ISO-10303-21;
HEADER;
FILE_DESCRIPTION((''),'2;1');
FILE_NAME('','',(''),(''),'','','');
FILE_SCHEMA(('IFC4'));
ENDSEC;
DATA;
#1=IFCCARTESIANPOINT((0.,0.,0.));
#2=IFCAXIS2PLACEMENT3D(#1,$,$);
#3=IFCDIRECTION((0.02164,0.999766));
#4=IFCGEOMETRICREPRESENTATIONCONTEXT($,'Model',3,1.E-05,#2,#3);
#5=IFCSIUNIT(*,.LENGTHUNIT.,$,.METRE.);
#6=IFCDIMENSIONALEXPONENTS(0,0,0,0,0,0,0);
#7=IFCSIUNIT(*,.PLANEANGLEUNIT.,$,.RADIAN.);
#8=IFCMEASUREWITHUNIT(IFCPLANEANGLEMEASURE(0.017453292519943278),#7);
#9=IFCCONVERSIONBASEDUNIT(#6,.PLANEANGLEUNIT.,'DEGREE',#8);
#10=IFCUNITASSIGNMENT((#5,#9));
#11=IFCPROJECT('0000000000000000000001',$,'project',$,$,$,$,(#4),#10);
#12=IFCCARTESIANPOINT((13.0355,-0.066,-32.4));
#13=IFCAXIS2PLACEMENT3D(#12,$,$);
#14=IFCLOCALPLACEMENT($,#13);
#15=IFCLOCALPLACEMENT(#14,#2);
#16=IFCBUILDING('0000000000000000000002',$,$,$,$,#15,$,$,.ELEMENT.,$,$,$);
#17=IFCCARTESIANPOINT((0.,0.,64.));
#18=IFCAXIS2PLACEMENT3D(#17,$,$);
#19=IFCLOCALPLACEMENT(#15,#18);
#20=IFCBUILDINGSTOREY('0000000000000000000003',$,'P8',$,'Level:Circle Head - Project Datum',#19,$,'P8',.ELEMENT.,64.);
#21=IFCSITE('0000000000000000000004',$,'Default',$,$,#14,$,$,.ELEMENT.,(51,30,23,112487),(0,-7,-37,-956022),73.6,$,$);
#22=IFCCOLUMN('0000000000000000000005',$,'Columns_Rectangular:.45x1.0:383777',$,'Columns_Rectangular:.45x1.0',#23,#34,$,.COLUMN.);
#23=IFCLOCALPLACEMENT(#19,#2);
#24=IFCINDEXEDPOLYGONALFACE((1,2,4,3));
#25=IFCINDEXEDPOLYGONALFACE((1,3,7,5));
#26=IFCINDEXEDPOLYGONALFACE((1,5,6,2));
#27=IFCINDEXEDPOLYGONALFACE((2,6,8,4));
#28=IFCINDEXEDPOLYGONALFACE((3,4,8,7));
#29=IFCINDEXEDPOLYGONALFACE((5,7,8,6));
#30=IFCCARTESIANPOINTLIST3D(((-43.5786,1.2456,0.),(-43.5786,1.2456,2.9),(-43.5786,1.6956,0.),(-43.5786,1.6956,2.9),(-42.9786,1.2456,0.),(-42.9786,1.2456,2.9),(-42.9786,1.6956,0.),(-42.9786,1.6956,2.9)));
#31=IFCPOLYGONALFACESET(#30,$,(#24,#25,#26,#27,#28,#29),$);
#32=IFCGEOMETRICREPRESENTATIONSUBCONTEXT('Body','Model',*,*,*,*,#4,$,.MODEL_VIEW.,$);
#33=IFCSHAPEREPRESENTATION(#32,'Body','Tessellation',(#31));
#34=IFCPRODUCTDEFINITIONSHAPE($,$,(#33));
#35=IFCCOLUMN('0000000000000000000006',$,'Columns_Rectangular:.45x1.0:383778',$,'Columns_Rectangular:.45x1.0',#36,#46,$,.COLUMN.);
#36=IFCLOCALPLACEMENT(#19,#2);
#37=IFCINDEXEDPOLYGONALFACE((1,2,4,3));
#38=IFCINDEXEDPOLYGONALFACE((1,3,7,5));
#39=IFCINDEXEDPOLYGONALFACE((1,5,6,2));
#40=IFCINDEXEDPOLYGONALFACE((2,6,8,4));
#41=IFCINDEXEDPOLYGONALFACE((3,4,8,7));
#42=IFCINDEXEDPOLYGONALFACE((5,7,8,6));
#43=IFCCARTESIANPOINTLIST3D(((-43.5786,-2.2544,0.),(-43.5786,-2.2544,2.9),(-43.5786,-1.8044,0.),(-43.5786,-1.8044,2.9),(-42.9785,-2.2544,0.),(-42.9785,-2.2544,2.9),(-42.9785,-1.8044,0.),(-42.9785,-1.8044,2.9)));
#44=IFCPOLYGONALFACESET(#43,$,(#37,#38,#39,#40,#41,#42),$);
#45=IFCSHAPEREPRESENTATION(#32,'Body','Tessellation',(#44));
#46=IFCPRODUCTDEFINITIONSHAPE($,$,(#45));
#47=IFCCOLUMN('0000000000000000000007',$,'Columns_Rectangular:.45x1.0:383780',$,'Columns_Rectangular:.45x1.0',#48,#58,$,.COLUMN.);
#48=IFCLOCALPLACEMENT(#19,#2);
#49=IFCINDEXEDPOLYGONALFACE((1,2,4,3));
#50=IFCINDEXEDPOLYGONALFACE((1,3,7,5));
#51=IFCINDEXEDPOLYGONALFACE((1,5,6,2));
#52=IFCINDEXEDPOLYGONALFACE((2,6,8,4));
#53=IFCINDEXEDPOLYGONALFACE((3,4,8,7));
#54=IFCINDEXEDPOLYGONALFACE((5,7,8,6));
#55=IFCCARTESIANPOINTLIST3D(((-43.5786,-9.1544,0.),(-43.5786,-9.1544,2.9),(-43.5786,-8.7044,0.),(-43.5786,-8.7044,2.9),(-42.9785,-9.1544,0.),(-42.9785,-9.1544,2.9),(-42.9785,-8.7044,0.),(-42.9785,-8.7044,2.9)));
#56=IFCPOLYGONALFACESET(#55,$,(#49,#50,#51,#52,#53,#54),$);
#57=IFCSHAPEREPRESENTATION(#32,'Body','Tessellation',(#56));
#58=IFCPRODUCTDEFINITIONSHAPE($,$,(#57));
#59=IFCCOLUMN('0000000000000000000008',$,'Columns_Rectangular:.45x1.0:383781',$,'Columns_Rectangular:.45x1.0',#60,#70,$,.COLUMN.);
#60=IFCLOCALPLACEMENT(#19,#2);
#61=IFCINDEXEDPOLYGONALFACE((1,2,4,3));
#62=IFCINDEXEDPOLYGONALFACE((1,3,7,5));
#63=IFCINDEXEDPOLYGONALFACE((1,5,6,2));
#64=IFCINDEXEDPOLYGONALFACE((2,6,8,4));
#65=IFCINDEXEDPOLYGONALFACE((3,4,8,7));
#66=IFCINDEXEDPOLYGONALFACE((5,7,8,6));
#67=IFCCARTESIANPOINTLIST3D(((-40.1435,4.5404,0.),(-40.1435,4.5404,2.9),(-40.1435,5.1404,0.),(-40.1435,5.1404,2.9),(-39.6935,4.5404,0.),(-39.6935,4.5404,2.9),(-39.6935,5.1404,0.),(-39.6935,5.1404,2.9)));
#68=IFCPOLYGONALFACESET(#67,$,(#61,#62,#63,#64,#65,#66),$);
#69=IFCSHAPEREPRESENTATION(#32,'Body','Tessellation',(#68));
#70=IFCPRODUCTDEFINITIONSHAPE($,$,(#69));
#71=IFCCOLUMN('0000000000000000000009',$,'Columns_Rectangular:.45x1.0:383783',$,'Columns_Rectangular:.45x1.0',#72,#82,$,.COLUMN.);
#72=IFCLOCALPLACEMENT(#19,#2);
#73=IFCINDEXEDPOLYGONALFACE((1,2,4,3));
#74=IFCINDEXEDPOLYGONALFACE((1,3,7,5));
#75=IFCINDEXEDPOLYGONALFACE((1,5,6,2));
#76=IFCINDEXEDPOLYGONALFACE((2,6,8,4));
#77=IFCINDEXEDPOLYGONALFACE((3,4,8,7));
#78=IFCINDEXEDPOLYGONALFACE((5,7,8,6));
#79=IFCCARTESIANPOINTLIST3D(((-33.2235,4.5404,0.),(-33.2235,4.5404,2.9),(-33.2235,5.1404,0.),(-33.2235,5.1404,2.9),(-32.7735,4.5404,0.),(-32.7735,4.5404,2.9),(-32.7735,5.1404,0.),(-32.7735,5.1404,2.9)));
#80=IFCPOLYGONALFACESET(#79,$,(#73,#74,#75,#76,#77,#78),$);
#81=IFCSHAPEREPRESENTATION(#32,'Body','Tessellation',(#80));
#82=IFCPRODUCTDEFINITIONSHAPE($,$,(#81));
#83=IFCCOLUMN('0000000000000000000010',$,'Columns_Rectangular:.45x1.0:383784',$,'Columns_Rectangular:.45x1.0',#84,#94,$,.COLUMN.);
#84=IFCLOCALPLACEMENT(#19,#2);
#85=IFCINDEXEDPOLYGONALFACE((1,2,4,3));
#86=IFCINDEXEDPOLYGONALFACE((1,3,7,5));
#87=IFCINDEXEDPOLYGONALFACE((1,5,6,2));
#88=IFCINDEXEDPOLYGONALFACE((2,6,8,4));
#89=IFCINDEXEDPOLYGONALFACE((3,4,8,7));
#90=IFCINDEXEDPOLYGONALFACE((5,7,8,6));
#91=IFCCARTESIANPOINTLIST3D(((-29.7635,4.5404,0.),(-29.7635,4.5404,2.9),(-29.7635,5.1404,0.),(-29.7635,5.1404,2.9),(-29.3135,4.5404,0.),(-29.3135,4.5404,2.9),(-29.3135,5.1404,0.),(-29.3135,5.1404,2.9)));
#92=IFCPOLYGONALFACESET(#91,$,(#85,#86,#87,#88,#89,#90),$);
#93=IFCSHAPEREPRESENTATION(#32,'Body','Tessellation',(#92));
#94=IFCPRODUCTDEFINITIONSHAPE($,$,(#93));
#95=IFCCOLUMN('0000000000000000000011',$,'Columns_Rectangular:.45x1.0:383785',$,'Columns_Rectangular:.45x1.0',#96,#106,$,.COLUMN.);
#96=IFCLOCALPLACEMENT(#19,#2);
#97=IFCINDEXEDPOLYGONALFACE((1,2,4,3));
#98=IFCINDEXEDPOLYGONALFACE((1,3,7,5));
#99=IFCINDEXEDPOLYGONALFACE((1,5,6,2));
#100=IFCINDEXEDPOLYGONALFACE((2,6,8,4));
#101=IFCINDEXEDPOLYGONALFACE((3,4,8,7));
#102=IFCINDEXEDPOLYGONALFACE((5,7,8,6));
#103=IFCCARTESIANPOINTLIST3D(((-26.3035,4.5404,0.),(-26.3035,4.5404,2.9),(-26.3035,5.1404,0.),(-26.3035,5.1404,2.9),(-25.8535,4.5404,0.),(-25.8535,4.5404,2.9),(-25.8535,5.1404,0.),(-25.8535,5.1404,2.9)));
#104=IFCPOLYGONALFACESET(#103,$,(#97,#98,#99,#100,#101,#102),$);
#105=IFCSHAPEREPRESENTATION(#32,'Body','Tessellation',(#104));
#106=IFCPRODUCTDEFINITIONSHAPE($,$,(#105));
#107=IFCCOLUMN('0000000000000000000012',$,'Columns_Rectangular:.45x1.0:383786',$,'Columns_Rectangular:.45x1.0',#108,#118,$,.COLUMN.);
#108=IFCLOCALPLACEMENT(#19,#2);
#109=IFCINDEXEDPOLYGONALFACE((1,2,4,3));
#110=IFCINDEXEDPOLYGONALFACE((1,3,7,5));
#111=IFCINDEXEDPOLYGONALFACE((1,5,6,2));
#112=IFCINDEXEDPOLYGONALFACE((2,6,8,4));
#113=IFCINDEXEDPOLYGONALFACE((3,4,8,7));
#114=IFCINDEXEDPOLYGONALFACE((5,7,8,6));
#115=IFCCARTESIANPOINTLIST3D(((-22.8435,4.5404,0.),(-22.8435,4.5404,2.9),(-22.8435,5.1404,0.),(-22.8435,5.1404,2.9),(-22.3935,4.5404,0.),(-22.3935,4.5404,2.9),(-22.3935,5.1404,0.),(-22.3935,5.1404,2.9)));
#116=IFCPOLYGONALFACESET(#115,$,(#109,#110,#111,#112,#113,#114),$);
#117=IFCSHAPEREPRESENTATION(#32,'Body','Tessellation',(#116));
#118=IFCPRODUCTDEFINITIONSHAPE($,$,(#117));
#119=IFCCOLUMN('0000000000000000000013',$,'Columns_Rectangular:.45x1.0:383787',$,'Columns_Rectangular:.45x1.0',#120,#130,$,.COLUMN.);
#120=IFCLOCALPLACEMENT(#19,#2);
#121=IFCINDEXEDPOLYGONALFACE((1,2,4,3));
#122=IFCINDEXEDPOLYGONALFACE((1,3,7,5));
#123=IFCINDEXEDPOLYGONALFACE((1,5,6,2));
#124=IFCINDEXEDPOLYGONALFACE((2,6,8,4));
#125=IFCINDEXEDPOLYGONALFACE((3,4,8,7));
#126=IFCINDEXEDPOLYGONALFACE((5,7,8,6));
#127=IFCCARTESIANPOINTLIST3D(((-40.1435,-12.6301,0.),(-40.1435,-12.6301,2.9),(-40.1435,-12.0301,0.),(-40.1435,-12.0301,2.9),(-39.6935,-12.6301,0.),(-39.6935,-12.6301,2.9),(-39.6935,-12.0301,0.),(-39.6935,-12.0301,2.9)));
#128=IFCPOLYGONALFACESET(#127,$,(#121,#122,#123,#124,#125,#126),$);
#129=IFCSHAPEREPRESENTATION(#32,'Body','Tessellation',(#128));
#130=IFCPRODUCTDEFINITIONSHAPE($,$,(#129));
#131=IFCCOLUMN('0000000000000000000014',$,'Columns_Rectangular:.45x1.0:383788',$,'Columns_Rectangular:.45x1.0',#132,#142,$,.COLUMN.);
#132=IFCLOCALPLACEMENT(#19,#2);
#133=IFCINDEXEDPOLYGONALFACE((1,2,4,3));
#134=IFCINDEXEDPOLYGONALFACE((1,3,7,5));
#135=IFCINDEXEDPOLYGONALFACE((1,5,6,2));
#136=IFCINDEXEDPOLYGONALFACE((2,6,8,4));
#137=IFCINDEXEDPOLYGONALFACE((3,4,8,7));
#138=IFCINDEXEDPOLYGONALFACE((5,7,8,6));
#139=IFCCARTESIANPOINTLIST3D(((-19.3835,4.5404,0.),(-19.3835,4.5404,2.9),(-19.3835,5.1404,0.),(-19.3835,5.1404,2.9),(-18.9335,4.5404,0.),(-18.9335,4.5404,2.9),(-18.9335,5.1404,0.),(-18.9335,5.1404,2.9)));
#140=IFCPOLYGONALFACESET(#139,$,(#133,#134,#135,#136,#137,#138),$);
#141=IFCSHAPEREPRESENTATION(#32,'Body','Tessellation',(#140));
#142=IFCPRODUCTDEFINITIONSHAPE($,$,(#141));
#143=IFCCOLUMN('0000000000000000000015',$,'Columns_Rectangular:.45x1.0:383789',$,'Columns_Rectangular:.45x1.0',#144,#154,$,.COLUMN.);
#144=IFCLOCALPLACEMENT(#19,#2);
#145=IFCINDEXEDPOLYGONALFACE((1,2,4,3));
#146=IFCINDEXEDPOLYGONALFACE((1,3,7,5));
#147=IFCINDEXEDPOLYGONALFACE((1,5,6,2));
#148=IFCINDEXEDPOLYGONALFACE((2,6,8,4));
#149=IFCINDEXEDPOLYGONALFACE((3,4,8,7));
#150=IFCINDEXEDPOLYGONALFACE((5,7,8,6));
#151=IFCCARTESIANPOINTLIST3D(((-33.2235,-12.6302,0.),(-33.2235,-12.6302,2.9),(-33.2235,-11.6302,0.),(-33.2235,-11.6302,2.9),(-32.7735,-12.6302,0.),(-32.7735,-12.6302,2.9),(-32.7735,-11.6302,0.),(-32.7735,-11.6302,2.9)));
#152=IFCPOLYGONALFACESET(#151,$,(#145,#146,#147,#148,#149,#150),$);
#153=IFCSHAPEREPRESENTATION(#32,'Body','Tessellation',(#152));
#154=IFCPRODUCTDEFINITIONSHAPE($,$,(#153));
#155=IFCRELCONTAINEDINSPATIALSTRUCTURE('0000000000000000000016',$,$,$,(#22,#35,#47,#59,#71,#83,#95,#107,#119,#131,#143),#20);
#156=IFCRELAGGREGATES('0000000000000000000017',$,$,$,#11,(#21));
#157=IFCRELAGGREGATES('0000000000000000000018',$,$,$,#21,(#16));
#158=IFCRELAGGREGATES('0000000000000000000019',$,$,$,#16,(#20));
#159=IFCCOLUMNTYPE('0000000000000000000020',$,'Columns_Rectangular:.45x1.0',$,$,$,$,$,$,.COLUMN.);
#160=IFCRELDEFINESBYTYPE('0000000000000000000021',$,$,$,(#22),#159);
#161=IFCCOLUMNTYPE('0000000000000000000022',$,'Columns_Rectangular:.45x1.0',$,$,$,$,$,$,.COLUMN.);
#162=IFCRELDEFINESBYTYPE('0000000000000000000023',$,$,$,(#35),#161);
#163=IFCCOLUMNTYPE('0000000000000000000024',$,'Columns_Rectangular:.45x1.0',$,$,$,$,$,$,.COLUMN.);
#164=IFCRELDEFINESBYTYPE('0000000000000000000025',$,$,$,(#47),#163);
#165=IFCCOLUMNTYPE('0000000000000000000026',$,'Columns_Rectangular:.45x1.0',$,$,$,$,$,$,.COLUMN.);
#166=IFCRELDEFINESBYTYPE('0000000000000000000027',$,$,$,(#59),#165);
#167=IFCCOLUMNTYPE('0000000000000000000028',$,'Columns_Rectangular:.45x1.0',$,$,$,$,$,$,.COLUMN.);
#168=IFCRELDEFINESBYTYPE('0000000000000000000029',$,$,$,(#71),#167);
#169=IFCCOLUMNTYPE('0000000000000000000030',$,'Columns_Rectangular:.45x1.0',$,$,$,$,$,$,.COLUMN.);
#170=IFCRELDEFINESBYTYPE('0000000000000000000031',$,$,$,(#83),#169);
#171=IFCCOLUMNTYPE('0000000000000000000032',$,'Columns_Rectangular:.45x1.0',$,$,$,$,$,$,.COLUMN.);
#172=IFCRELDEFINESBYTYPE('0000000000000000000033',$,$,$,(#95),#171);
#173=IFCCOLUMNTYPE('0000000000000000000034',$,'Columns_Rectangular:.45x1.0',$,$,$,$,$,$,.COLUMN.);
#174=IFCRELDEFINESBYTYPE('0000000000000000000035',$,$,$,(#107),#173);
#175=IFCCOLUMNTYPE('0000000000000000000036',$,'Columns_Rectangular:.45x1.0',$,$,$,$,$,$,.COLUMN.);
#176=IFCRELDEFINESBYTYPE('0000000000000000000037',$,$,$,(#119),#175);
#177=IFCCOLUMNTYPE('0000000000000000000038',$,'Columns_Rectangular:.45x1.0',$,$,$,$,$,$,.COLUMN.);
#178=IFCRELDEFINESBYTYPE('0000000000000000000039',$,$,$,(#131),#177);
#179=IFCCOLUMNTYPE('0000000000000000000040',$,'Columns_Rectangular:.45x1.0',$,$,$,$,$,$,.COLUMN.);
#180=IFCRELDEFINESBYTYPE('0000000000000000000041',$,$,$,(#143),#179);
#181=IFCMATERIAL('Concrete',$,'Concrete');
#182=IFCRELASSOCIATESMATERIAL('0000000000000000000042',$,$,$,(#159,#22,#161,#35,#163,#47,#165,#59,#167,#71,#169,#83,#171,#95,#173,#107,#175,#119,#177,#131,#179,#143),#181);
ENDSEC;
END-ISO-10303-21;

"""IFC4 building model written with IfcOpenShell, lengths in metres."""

from ifc_helpers import new_model, entity, si_unit, converted_unit, direction, frame, origin, place, context, subcontext, project, spatial, indexed_curve, outline, extrude, source, transform, mapped, material, type_object, type_shapes, element, save


model = new_model("IFC4")

# Units and contexts
model_context = context("Model", 3, precision=1e-05, world=origin(), true_north=direction((0.02164, 0.999766)))
body_context = subcontext(model_context, "Body", "Model", "MODEL_VIEW")
ifc_project = project(units=[si_unit("LENGTHUNIT", "METRE"), converted_unit("PLANEANGLEUNIT", "DEGREE", entity("IfcPlaneAngleMeasure", 0.017453292519943278), si_unit("PLANEANGLEUNIT", "RADIAN"), dimensions=[0, 0, 0, 0, 0, 0, 0])], contexts=[model_context])

# Site, building, storey
site_placement = place(None, frame((13.0355, -0.066, -32.4)))
site = spatial("IfcSite", under=ifc_project, at=site_placement, Name="Default", CompositionType="ELEMENT", RefLatitude=(51, 30, 23, 112487), RefLongitude=(0, -7, -37, -956022), RefElevation=73.6)
building_placement = place(site_placement, origin())
building = spatial("IfcBuilding", under=site, at=building_placement, CompositionType="ELEMENT")
storey_placement = place(building_placement, frame((0.0, 0.0, 64.0)))
storey = spatial("IfcBuildingStorey", under=building, at=storey_placement, Name="P8", ObjectType="Level:Circle Head - Project Datum", LongName="P8", CompositionType="ELEMENT", Elevation=64.0)

# Columns
ifc_material = material(Name="Concrete", Category="Concrete")
column_type_1 = type_object("IfcColumnType", Name="Columns_Rectangular:.45x1.0", PredefinedType="COLUMN", material=ifc_material)
shared_shape_1 = source(origin(), body_context, "Body", "SweptSolid", [
    extrude(outline(indexed_curve([(-0.3, -0.225), (0.3, -0.225), (0.3, 0.225), (-0.3, 0.225), (-0.3, -0.225)], self_intersect=False)), frame((-43.2786, 1.4706, 64.0)), (0.0, 0.0, 1.0), 2.9),
])
type_shapes(column_type_1, [shared_shape_1])
column_1_placement = place(storey_placement, frame((0.0, 0.0, -64.0)))
element("IfcColumn", 1, at=column_1_placement, inside=storey, type_object=column_type_1, material=ifc_material, Name="Columns_Rectangular:.45x1.0:383777", ObjectType="Columns_Rectangular:.45x1.0", PredefinedType="COLUMN", context=body_context, shape_type="MappedRepresentation", body=[
    mapped(shared_shape_1, transform((0.0, 0.0, 0.0), scale=1.0)),
])
column_type_2 = type_object("IfcColumnType", Name="Columns_Rectangular:.45x1.0", PredefinedType="COLUMN", material=ifc_material)
shared_shape_2 = source(origin(), body_context, "Body", "SweptSolid", [
    extrude(outline(indexed_curve([(-0.3, -0.225), (0.3, -0.225), (0.3, 0.225), (-0.3, 0.225), (-0.3, -0.225)], self_intersect=False)), frame((-43.2785, -2.0294, 64.0)), (0.0, 0.0, 1.0), 2.9),
])
type_shapes(column_type_2, [shared_shape_2])
column_2_placement = place(storey_placement, frame((0.0, 0.0, -64.0)))
element("IfcColumn", 2, at=column_2_placement, inside=storey, type_object=column_type_2, material=ifc_material, Name="Columns_Rectangular:.45x1.0:383778", ObjectType="Columns_Rectangular:.45x1.0", PredefinedType="COLUMN", context=body_context, shape_type="MappedRepresentation", body=[
    mapped(shared_shape_2, transform((0.0, 0.0, 0.0), scale=1.0)),
])
column_type_3 = type_object("IfcColumnType", Name="Columns_Rectangular:.45x1.0", PredefinedType="COLUMN", material=ifc_material)
shared_shape_3 = source(origin(), body_context, "Body", "SweptSolid", [
    extrude(outline(indexed_curve([(-0.3, -0.225), (0.3, -0.225), (0.3, 0.225), (-0.3, 0.225), (-0.3, -0.225)], self_intersect=False)), frame((-43.2785, -8.9294, 64.0)), (0.0, 0.0, 1.0), 2.9),
])
type_shapes(column_type_3, [shared_shape_3])
column_3_placement = place(storey_placement, frame((0.0, 0.0, -64.0)))
element("IfcColumn", 3, at=column_3_placement, inside=storey, type_object=column_type_3, material=ifc_material, Name="Columns_Rectangular:.45x1.0:383780", ObjectType="Columns_Rectangular:.45x1.0", PredefinedType="COLUMN", context=body_context, shape_type="MappedRepresentation", body=[
    mapped(shared_shape_3, transform((0.0, 0.0, 0.0), scale=1.0)),
])
column_type_4 = type_object("IfcColumnType", Name="Columns_Rectangular:.45x1.0", PredefinedType="COLUMN", material=ifc_material)
shared_shape_4 = source(origin(), body_context, "Body", "SweptSolid", [
    extrude(outline(indexed_curve([(-0.3, -0.225), (0.3, -0.225), (0.3, 0.225), (-0.3, 0.225), (-0.3, -0.225)], self_intersect=False)), frame((-39.9185, 4.8404, 64.0), z_axis=(0.0, 0.0, 1.0), x_axis=(0.0, -1.0, 0.0)), (0.0, 0.0, 1.0), 2.9),
])
type_shapes(column_type_4, [shared_shape_4])
column_4_placement = place(storey_placement, frame((0.0, 0.0, -64.0)))
element("IfcColumn", 4, at=column_4_placement, inside=storey, type_object=column_type_4, material=ifc_material, Name="Columns_Rectangular:.45x1.0:383781", ObjectType="Columns_Rectangular:.45x1.0", PredefinedType="COLUMN", context=body_context, shape_type="MappedRepresentation", body=[
    mapped(shared_shape_4, transform((0.0, 0.0, 0.0), scale=1.0)),
])
column_type_5 = type_object("IfcColumnType", Name="Columns_Rectangular:.45x1.0", PredefinedType="COLUMN", material=ifc_material)
shared_shape_5 = source(origin(), body_context, "Body", "SweptSolid", [
    extrude(outline(indexed_curve([(-0.3, -0.225), (0.3, -0.225), (0.3, 0.225), (-0.3, 0.225), (-0.3, -0.225)], self_intersect=False)), frame((-32.9985, 4.8404, 64.0), z_axis=(0.0, 0.0, 1.0), x_axis=(0.0, -1.0, 0.0)), (0.0, 0.0, 1.0), 2.9),
])
type_shapes(column_type_5, [shared_shape_5])
column_5_placement = place(storey_placement, frame((0.0, 0.0, -64.0)))
element("IfcColumn", 5, at=column_5_placement, inside=storey, type_object=column_type_5, material=ifc_material, Name="Columns_Rectangular:.45x1.0:383783", ObjectType="Columns_Rectangular:.45x1.0", PredefinedType="COLUMN", context=body_context, shape_type="MappedRepresentation", body=[
    mapped(shared_shape_5, transform((0.0, 0.0, 0.0), scale=1.0)),
])
column_type_6 = type_object("IfcColumnType", Name="Columns_Rectangular:.45x1.0", PredefinedType="COLUMN", material=ifc_material)
shared_shape_6 = source(origin(), body_context, "Body", "SweptSolid", [
    extrude(outline(indexed_curve([(-0.3, -0.225), (0.3, -0.225), (0.3, 0.225), (-0.3, 0.225), (-0.3, -0.225)], self_intersect=False)), frame((-29.5385, 4.8404, 64.0), z_axis=(0.0, 0.0, 1.0), x_axis=(0.0, -1.0, 0.0)), (0.0, 0.0, 1.0), 2.9),
])
type_shapes(column_type_6, [shared_shape_6])
column_6_placement = place(storey_placement, frame((0.0, 0.0, -64.0)))
element("IfcColumn", 6, at=column_6_placement, inside=storey, type_object=column_type_6, material=ifc_material, Name="Columns_Rectangular:.45x1.0:383784", ObjectType="Columns_Rectangular:.45x1.0", PredefinedType="COLUMN", context=body_context, shape_type="MappedRepresentation", body=[
    mapped(shared_shape_6, transform((0.0, 0.0, 0.0), scale=1.0)),
])
column_type_7 = type_object("IfcColumnType", Name="Columns_Rectangular:.45x1.0", PredefinedType="COLUMN", material=ifc_material)
shared_shape_7 = source(origin(), body_context, "Body", "SweptSolid", [
    extrude(outline(indexed_curve([(-0.3, -0.225), (0.3, -0.225), (0.3, 0.225), (-0.3, 0.225), (-0.3, -0.225)], self_intersect=False)), frame((-26.0785, 4.8404, 64.0), z_axis=(0.0, 0.0, 1.0), x_axis=(0.0, -1.0, 0.0)), (0.0, 0.0, 1.0), 2.9),
])
type_shapes(column_type_7, [shared_shape_7])
column_7_placement = place(storey_placement, frame((0.0, 0.0, -64.0)))
element("IfcColumn", 7, at=column_7_placement, inside=storey, type_object=column_type_7, material=ifc_material, Name="Columns_Rectangular:.45x1.0:383785", ObjectType="Columns_Rectangular:.45x1.0", PredefinedType="COLUMN", context=body_context, shape_type="MappedRepresentation", body=[
    mapped(shared_shape_7, transform((0.0, 0.0, 0.0), scale=1.0)),
])
column_type_8 = type_object("IfcColumnType", Name="Columns_Rectangular:.45x1.0", PredefinedType="COLUMN", material=ifc_material)
shared_shape_8 = source(origin(), body_context, "Body", "SweptSolid", [
    extrude(outline(indexed_curve([(-0.3, -0.225), (0.3, -0.225), (0.3, 0.225), (-0.3, 0.225), (-0.3, -0.225)], self_intersect=False)), frame((-22.6185, 4.8404, 64.0), z_axis=(0.0, 0.0, 1.0), x_axis=(0.0, -1.0, 0.0)), (0.0, 0.0, 1.0), 2.9),
])
type_shapes(column_type_8, [shared_shape_8])
column_8_placement = place(storey_placement, frame((0.0, 0.0, -64.0)))
element("IfcColumn", 8, at=column_8_placement, inside=storey, type_object=column_type_8, material=ifc_material, Name="Columns_Rectangular:.45x1.0:383786", ObjectType="Columns_Rectangular:.45x1.0", PredefinedType="COLUMN", context=body_context, shape_type="MappedRepresentation", body=[
    mapped(shared_shape_8, transform((0.0, 0.0, 0.0), scale=1.0)),
])
column_type_9 = type_object("IfcColumnType", Name="Columns_Rectangular:.45x1.0", PredefinedType="COLUMN", material=ifc_material)
shared_shape_9 = source(origin(), body_context, "Body", "SweptSolid", [
    extrude(outline(indexed_curve([(-0.3, -0.225), (0.3, -0.225), (0.3, 0.225), (-0.3, 0.225), (-0.3, -0.225)], self_intersect=False)), frame((-39.9185, -12.3301, 64.0), z_axis=(0.0, 0.0, 1.0), x_axis=(0.000011, 1.0, 0.0)), (0.0, 0.0, 1.0), 2.9),
])
type_shapes(column_type_9, [shared_shape_9])
column_9_placement = place(storey_placement, frame((0.0, 0.0, -64.0)))
element("IfcColumn", 9, at=column_9_placement, inside=storey, type_object=column_type_9, material=ifc_material, Name="Columns_Rectangular:.45x1.0:383787", ObjectType="Columns_Rectangular:.45x1.0", PredefinedType="COLUMN", context=body_context, shape_type="MappedRepresentation", body=[
    mapped(shared_shape_9, transform((0.0, 0.0, 0.0), scale=1.0)),
])
column_type_10 = type_object("IfcColumnType", Name="Columns_Rectangular:.45x1.0", PredefinedType="COLUMN", material=ifc_material)
shared_shape_10 = source(origin(), body_context, "Body", "SweptSolid", [
    extrude(outline(indexed_curve([(-0.3, -0.225), (0.3, -0.225), (0.3, 0.225), (-0.3, 0.225), (-0.3, -0.225)], self_intersect=False)), frame((-19.1585, 4.8404, 64.0), z_axis=(0.0, 0.0, 1.0), x_axis=(0.0, -1.0, 0.0)), (0.0, 0.0, 1.0), 2.9),
])
type_shapes(column_type_10, [shared_shape_10])
column_10_placement = place(storey_placement, frame((0.0, 0.0, -64.0)))
element("IfcColumn", 10, at=column_10_placement, inside=storey, type_object=column_type_10, material=ifc_material, Name="Columns_Rectangular:.45x1.0:383788", ObjectType="Columns_Rectangular:.45x1.0", PredefinedType="COLUMN", context=body_context, shape_type="MappedRepresentation", body=[
    mapped(shared_shape_10, transform((0.0, 0.0, 0.0), scale=1.0)),
])
column_type_11 = type_object("IfcColumnType", Name="Columns_Rectangular:.45x1.0", PredefinedType="COLUMN", material=ifc_material)
shared_shape_11 = source(origin(), body_context, "Body", "SweptSolid", [
    extrude(outline(indexed_curve([(-0.5, -0.225), (0.5, -0.225), (0.5, 0.225), (-0.5, 0.225), (-0.5, -0.225)], self_intersect=False)), frame((-32.9985, -12.1302, 64.0), z_axis=(0.0, 0.0, 1.0), x_axis=(0.000011, 1.0, 0.0)), (0.0, 0.0, 1.0), 2.9),
])
type_shapes(column_type_11, [shared_shape_11])
column_11_placement = place(storey_placement, frame((0.0, 0.0, -64.0)))
element("IfcColumn", 11, at=column_11_placement, inside=storey, type_object=column_type_11, material=ifc_material, Name="Columns_Rectangular:.45x1.0:383789", ObjectType="Columns_Rectangular:.45x1.0", PredefinedType="COLUMN", context=body_context, shape_type="MappedRepresentation", body=[
    mapped(shared_shape_11, transform((0.0, 0.0, 0.0), scale=1.0)),
])

save(model, "model.ifc")
